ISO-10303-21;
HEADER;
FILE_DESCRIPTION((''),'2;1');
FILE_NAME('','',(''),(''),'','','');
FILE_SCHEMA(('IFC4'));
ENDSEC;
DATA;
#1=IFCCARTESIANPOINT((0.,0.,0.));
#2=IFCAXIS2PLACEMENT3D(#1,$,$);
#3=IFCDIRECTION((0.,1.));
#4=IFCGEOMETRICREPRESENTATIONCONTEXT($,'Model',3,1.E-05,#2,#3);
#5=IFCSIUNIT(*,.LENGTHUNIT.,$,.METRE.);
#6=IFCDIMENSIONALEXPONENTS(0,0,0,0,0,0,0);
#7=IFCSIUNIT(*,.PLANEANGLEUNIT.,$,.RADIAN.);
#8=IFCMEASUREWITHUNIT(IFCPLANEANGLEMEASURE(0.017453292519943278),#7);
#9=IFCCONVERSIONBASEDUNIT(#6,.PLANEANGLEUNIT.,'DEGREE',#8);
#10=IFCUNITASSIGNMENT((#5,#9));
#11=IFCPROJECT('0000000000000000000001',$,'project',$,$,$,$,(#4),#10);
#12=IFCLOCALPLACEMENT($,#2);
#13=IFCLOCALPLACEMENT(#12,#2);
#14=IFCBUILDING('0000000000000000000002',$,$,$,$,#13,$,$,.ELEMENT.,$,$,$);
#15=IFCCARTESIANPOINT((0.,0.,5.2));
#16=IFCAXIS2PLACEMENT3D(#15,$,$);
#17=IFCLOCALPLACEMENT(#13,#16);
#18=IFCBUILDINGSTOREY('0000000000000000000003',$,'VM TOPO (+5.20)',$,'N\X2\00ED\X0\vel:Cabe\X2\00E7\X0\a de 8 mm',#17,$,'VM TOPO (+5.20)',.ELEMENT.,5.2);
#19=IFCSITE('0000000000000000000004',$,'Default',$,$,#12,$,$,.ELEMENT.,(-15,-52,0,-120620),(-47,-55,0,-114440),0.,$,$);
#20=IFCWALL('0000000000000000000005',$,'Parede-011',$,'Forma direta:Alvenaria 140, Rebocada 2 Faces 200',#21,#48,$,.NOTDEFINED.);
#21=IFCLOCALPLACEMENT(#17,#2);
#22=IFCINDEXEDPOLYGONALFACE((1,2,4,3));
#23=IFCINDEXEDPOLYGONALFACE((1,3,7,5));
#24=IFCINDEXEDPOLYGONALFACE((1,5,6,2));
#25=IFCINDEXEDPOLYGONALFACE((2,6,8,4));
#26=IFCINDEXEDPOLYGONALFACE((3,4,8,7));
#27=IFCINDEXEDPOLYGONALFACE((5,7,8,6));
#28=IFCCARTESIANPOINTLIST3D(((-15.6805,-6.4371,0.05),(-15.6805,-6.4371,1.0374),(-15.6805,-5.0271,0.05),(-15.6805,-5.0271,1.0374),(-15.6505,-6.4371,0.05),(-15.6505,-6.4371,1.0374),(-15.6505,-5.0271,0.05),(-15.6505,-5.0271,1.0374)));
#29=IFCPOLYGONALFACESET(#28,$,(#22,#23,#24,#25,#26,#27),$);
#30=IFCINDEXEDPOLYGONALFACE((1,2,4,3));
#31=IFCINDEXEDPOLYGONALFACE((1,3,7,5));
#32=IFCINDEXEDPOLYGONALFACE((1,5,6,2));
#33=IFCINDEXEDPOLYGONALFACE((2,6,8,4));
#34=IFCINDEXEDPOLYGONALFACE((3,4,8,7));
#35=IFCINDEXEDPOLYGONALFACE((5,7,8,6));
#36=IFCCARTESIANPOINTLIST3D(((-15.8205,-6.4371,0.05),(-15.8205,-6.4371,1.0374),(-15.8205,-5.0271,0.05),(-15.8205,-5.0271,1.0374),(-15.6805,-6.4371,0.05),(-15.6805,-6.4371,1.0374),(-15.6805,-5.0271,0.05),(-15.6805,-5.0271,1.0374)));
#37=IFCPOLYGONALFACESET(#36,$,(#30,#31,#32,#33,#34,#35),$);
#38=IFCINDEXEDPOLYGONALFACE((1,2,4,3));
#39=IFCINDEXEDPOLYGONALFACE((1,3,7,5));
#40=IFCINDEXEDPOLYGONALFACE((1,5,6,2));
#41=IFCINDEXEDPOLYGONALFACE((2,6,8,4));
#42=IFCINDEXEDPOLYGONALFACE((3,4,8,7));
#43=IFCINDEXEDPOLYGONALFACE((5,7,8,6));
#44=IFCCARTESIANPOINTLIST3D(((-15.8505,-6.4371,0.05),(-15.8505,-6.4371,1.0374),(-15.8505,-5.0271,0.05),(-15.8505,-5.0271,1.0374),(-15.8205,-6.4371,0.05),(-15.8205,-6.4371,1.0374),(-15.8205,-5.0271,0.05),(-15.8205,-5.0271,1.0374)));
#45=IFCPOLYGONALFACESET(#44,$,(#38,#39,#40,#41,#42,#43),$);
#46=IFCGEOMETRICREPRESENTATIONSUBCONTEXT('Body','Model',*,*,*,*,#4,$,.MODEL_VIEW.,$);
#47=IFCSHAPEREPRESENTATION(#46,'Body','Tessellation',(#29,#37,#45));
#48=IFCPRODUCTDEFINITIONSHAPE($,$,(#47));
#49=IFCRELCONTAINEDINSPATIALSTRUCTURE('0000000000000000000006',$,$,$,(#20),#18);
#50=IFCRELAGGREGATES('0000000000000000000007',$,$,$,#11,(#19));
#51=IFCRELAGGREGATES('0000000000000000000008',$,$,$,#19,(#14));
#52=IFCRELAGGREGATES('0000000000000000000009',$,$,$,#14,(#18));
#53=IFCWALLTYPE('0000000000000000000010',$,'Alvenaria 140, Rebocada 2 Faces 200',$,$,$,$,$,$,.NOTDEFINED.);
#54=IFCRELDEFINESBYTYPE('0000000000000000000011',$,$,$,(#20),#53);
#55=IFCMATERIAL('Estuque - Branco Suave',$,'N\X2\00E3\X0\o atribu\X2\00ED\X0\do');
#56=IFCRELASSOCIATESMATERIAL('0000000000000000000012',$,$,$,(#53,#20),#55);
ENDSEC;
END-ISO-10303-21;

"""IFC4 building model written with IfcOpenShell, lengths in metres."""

from ifc_helpers import new_model, entity, si_unit, converted_unit, direction, frame, origin, place, context, subcontext, project, spatial, indexed_curve, outline, extrude, material, type_object, element, save


model = new_model("IFC4")

# Units and contexts
model_context = context("Model", 3, precision=1e-05, world=origin(), true_north=direction((0.0, 1.0)))
body_context = subcontext(model_context, "Body", "Model", "MODEL_VIEW")
ifc_project = project(units=[si_unit("LENGTHUNIT", "METRE"), converted_unit("PLANEANGLEUNIT", "DEGREE", entity("IfcPlaneAngleMeasure", 0.017453292519943278), si_unit("PLANEANGLEUNIT", "RADIAN"), dimensions=[0, 0, 0, 0, 0, 0, 0])], contexts=[model_context])

# Site, building, storey
site_placement = place(None, origin())
site = spatial("IfcSite", under=ifc_project, at=site_placement, Name="Default", CompositionType="ELEMENT", RefLatitude=(-15, -52, 0, -120620), RefLongitude=(-47, -55, 0, -114440), RefElevation=0.0)
building_placement = place(site_placement, origin())
building = spatial("IfcBuilding", under=site, at=building_placement, CompositionType="ELEMENT")
storey_placement = place(building_placement, frame((0.0, 0.0, 5.2)))
storey = spatial("IfcBuildingStorey", under=building, at=storey_placement, Name="VM TOPO (+5.20)", ObjectType="Nível:Cabeça de 8 mm", LongName="VM TOPO (+5.20)", CompositionType="ELEMENT", Elevation=5.2)

# Wall
ifc_material = material(Name="Estuque - Branco Suave", Category="Não atribuído")
wall_type = type_object("IfcWallType", Name="Alvenaria 140, Rebocada 2 Faces 200", PredefinedType="NOTDEFINED", material=ifc_material)
wall_placement = place(storey_placement, frame((-15.8505, -6.4371, 0.05), z_axis=(0.0, 0.0, 1.0), x_axis=(0.0, 1.0, 0.0)))
element("IfcWall", 1, at=wall_placement, inside=storey, type_object=wall_type, material=ifc_material, Name="Parede-011", ObjectType="Forma direta:Alvenaria 140, Rebocada 2 Faces 200", PredefinedType="NOTDEFINED", context=body_context, shape_type="SweptSolid", body=[
    extrude(outline(indexed_curve([(-0.015, -0.705), (0.015, -0.705), (0.015, 0.705), (-0.015, 0.705), (-0.015, -0.705)], self_intersect=False)), frame((0.705, -0.185, 0.0), z_axis=(0.0, 0.0, 1.0), x_axis=(-0.000013, -1.0, 0.0)), (0.0, 0.0, 1.0), 0.9874),
    extrude(outline(indexed_curve([(-0.07, -0.705), (0.07, -0.705), (0.07, 0.705), (-0.07, 0.705), (-0.07, -0.705)], self_intersect=False)), frame((0.705, -0.1, 0.0), z_axis=(0.0, 0.0, 1.0), x_axis=(0.000013, 1.0, 0.0)), (0.0, 0.0, 1.0), 0.9874),
    extrude(outline(indexed_curve([(-0.015, -0.705), (0.015, -0.705), (0.015, 0.705), (-0.015, 0.705), (-0.015, -0.705)], self_intersect=False)), frame((0.705, -0.015, 0.0), z_axis=(0.0, 0.0, 1.0), x_axis=(0.000013, 1.0, 0.0)), (0.0, 0.0, 1.0), 0.9874),
])

save(model, "model.ifc")
